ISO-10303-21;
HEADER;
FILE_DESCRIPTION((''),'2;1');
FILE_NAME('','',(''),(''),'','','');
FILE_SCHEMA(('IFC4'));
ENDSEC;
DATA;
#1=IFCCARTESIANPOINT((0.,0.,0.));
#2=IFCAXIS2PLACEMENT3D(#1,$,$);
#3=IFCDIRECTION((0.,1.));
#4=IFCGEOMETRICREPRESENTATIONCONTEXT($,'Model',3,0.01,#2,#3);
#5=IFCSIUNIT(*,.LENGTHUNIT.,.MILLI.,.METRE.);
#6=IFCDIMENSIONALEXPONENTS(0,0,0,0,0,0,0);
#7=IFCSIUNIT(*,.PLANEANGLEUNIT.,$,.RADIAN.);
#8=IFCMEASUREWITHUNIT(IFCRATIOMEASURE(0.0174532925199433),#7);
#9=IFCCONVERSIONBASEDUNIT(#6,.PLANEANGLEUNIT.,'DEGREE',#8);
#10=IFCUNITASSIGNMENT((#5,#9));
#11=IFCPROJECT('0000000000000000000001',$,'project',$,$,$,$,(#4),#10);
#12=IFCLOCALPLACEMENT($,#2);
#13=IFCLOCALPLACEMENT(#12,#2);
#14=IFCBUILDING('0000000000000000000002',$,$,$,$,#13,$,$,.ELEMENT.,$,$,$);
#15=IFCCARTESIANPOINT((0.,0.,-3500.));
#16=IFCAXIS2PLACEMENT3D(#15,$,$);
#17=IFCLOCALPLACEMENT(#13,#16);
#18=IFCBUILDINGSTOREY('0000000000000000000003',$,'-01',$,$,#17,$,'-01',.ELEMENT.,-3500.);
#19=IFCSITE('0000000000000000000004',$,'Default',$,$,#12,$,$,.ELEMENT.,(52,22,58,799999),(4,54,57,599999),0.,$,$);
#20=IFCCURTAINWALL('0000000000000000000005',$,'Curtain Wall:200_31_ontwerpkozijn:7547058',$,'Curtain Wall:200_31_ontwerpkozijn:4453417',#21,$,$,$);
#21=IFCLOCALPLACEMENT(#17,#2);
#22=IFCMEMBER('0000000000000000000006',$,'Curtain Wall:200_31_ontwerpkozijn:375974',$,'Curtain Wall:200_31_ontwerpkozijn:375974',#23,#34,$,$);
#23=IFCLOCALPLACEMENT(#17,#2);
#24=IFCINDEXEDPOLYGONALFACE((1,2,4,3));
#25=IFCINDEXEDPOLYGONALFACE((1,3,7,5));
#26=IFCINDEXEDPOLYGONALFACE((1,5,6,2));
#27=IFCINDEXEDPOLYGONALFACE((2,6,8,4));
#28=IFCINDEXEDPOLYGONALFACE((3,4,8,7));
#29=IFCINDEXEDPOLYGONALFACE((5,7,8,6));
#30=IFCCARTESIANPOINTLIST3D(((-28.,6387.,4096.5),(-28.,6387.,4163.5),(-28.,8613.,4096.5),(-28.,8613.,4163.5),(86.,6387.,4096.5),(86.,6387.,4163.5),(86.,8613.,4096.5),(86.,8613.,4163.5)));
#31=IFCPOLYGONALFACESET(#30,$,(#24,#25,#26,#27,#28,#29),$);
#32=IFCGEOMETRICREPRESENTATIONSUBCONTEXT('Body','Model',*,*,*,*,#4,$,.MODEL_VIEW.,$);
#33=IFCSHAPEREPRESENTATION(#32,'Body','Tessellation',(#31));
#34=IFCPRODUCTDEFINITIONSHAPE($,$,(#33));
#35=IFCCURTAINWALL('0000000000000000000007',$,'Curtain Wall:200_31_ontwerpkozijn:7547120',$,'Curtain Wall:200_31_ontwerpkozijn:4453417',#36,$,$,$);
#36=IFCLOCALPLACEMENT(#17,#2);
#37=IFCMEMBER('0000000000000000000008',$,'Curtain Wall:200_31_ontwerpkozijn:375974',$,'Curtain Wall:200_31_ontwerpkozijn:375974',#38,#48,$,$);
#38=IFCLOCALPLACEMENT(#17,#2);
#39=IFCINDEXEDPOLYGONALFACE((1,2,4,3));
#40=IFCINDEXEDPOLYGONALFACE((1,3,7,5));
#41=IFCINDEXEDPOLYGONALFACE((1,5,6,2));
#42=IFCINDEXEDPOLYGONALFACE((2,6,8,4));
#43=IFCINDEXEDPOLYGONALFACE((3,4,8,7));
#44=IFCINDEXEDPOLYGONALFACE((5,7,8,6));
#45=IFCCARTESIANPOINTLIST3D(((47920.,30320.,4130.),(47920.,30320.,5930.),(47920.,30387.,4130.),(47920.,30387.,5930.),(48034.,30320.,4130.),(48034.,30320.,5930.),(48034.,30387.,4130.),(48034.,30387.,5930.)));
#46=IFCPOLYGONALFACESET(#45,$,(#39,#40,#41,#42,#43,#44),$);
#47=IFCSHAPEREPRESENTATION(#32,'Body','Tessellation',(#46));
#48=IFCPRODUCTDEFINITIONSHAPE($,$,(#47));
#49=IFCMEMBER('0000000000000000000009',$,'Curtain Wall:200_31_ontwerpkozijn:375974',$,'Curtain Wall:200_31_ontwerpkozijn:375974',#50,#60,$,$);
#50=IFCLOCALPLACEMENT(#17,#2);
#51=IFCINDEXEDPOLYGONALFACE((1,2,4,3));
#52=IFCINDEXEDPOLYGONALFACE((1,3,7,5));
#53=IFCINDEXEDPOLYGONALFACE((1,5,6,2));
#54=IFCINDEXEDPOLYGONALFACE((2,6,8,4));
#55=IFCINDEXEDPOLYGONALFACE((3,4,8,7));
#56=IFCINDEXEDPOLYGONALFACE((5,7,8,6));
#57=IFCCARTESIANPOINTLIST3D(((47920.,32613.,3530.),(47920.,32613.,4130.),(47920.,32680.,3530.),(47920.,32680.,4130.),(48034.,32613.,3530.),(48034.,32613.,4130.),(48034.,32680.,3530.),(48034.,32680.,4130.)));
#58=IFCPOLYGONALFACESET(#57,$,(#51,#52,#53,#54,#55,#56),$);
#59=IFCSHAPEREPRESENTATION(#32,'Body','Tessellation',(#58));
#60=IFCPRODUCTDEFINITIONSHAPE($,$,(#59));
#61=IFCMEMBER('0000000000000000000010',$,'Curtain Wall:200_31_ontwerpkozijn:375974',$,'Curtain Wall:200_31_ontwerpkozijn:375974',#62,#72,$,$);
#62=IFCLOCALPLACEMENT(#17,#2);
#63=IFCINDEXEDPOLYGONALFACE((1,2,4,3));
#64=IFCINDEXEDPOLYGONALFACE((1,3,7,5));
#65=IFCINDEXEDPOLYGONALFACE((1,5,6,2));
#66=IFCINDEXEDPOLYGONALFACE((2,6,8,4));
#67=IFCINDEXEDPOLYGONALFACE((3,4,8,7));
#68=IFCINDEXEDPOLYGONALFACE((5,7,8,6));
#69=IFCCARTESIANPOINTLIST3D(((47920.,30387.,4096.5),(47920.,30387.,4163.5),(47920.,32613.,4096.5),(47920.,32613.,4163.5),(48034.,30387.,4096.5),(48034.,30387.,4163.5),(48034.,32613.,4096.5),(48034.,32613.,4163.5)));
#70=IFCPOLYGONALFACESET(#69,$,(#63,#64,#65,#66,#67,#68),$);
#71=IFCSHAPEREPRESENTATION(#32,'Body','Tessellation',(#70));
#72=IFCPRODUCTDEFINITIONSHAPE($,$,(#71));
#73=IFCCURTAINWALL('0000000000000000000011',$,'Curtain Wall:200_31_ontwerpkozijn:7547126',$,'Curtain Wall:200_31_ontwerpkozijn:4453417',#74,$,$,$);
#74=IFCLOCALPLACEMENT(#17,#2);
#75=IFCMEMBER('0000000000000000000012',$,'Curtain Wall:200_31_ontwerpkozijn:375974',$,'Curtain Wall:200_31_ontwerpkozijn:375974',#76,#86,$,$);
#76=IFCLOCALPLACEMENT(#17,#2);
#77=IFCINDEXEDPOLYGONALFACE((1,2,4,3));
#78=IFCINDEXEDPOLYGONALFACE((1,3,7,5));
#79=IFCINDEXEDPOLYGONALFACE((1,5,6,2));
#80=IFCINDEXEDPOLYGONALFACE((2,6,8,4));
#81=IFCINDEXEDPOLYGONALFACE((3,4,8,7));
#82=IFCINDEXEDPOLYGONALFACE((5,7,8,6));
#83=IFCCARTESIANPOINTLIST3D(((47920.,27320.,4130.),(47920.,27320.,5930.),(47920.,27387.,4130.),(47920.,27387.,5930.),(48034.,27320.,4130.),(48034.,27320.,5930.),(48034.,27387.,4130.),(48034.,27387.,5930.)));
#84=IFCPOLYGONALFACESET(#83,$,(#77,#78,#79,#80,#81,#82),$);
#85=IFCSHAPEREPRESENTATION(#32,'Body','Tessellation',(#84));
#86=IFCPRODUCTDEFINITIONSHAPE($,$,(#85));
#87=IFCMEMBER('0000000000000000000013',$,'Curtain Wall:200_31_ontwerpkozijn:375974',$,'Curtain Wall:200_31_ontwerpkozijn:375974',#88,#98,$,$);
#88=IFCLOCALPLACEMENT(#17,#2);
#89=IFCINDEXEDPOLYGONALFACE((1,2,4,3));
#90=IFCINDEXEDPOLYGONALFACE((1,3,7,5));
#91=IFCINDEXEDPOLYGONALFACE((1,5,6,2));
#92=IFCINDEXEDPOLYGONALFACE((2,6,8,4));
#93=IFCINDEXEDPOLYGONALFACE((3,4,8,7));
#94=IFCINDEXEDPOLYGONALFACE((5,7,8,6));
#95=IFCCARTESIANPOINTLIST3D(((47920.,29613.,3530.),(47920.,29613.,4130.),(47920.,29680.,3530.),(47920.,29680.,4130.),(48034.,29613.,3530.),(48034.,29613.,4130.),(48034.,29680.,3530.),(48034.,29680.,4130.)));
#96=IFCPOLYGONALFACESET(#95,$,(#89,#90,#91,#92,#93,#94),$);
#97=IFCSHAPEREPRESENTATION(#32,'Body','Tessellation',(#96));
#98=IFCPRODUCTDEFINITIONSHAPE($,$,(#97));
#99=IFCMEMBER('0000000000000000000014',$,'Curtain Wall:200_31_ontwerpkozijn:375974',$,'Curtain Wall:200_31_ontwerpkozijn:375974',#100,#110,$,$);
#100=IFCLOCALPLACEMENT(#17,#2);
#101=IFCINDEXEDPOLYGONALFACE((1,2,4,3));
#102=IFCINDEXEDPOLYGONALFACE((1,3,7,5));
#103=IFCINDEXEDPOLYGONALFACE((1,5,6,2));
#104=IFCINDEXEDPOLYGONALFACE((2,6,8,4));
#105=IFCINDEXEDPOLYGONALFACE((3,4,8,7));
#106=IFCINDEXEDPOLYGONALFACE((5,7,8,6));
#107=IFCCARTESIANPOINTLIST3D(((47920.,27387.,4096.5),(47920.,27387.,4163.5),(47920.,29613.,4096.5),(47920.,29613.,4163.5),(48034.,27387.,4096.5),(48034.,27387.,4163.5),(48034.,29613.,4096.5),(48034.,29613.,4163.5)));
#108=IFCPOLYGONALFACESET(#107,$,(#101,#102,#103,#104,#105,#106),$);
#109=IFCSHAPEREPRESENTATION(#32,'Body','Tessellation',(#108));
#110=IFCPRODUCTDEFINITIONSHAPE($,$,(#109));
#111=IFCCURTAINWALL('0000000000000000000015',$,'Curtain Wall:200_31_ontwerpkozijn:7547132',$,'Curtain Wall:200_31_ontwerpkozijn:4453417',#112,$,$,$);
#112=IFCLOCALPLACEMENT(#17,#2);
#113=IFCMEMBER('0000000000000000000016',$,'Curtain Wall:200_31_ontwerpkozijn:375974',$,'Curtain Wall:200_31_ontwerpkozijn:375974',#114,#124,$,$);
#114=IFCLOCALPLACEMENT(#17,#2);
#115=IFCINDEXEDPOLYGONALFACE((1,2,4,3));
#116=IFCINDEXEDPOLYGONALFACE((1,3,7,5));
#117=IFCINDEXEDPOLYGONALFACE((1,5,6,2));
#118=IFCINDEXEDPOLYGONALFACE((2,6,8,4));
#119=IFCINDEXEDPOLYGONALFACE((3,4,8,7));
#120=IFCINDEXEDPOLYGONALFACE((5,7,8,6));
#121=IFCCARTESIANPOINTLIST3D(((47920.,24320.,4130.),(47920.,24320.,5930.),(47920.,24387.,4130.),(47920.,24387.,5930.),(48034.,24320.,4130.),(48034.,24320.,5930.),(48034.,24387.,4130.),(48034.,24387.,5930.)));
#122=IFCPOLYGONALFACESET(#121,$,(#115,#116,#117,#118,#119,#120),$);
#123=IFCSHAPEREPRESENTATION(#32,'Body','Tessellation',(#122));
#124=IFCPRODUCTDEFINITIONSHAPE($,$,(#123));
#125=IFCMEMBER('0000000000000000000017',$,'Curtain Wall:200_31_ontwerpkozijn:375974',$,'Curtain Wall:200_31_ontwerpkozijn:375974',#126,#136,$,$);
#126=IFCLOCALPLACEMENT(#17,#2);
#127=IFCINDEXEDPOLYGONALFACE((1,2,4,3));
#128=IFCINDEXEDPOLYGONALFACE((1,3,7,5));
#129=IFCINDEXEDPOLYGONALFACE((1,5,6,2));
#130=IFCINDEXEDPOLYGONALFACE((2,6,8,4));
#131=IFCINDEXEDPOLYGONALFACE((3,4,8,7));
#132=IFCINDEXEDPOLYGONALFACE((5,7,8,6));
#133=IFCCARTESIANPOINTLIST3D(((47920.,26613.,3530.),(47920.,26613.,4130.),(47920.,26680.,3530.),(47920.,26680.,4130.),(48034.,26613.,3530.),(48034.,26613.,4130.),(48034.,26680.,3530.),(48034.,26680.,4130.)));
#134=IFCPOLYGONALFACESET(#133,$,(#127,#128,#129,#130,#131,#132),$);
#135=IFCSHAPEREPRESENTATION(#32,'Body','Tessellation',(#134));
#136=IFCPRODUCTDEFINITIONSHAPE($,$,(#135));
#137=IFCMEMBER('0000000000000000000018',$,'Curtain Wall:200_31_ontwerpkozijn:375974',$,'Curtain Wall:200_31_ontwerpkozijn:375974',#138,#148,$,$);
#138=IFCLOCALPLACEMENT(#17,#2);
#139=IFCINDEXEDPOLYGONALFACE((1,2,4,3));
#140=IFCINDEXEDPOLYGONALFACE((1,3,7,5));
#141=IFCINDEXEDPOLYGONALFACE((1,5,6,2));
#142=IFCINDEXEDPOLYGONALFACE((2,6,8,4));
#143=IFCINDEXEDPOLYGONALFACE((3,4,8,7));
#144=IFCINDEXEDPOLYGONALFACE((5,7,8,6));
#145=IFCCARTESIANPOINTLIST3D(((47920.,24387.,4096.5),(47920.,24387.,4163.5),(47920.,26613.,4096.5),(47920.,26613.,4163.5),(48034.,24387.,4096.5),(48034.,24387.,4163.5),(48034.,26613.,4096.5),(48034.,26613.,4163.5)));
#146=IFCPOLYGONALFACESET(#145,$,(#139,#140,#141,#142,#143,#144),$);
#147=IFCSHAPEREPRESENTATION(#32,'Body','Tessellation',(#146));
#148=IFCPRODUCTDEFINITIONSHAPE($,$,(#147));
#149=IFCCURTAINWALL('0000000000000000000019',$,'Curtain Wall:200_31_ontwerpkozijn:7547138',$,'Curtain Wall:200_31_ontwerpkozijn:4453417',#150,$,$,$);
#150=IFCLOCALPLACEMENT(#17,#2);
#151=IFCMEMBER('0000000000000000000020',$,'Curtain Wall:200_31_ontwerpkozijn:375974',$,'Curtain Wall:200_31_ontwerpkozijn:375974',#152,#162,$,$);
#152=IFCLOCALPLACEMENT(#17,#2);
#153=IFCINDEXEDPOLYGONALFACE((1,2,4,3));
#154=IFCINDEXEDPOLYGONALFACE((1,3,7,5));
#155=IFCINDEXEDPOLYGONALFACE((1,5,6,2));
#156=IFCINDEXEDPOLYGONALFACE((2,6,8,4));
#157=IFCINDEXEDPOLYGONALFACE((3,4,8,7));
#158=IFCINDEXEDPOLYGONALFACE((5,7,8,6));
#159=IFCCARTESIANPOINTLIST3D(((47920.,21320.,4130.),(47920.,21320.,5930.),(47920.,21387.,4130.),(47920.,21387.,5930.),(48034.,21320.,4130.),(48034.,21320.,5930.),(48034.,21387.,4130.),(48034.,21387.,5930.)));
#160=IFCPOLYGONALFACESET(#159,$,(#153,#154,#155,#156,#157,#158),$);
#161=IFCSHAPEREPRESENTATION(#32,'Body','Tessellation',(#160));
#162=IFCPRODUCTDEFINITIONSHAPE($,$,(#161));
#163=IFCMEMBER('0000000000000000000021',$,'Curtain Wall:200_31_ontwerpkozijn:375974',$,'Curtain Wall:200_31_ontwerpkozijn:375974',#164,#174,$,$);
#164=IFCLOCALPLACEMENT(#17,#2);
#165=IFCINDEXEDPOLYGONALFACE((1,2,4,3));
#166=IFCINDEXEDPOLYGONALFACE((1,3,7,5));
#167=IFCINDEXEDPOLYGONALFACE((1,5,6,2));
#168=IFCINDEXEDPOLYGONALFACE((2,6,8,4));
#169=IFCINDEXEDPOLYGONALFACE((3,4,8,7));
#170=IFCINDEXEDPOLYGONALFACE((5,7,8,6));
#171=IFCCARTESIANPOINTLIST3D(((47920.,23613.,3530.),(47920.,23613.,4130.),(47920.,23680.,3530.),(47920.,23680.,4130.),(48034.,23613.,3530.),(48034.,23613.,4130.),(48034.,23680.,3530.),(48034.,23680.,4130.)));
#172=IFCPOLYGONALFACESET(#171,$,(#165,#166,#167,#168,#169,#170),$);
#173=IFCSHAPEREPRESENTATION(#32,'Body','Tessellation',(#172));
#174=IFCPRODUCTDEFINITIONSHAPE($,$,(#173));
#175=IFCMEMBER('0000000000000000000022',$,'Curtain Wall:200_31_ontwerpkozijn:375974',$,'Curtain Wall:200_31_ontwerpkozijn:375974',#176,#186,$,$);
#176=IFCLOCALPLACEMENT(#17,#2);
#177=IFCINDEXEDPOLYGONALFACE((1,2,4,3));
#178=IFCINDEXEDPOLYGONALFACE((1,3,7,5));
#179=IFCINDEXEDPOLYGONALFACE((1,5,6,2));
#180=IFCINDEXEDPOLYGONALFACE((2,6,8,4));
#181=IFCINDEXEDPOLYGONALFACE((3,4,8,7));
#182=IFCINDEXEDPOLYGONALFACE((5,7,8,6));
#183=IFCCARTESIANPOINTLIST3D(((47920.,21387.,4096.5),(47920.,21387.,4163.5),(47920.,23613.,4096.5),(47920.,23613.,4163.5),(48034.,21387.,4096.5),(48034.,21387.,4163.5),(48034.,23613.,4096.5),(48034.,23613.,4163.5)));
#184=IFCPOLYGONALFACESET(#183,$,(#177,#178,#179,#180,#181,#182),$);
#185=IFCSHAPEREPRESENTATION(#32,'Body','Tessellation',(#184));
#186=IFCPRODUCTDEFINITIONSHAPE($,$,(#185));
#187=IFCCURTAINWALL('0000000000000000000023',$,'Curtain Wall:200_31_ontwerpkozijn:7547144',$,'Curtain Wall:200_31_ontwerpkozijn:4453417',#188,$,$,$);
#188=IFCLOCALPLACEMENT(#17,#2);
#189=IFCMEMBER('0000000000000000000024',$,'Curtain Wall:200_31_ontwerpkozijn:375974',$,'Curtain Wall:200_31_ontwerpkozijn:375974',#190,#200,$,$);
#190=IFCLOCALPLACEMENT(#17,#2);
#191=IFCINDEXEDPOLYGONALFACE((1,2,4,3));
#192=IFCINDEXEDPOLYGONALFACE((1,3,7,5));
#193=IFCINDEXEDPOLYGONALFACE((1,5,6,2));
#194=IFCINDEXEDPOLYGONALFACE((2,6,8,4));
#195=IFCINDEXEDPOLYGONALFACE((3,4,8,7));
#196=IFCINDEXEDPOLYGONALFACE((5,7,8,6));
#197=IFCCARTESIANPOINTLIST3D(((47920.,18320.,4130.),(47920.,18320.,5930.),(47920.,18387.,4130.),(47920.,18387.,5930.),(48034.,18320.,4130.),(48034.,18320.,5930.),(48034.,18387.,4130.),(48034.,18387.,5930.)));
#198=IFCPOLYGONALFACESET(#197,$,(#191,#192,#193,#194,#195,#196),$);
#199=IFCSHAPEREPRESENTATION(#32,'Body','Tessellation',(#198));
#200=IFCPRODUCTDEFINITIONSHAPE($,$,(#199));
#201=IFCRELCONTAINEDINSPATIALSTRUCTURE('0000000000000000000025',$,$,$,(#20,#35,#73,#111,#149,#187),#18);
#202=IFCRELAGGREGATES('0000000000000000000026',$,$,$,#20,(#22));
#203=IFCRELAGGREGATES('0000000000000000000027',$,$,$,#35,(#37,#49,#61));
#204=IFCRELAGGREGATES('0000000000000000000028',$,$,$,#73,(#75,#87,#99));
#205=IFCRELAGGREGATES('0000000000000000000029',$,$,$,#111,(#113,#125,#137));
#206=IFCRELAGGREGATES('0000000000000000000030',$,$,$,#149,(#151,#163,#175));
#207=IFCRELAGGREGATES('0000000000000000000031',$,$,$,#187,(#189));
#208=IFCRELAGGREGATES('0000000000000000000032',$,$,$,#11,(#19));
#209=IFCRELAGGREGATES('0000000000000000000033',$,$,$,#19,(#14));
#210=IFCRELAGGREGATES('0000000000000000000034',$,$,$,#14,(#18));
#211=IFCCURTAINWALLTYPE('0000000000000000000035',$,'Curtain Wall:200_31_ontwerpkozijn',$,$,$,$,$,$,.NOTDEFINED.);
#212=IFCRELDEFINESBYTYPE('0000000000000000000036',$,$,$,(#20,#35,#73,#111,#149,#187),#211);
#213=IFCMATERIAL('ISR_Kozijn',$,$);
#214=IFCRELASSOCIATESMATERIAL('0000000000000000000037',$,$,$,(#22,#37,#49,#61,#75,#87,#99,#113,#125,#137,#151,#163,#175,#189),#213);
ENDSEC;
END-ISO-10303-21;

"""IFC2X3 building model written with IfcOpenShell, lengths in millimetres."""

from ifc_helpers import new_model, entity, si_unit, converted_unit, direction, frame, frame_2d, origin, place, context, subcontext, project, spatial, rectangle, extrude, material, type_object, element, aggregate, save


model = new_model("IFC2X3")

# Units and contexts
model_context = context("Model", 3, precision=0.01, world=origin(), true_north=direction((0.0, 1.0)))
body_context = subcontext(model_context, "Body", "Model", "MODEL_VIEW")
ifc_project = project(units=[si_unit("LENGTHUNIT", "METRE", prefix="MILLI"), converted_unit("PLANEANGLEUNIT", "DEGREE", entity("IfcRatioMeasure", 0.0174532925199433), si_unit("PLANEANGLEUNIT", "RADIAN"), dimensions=[0, 0, 0, 0, 0, 0, 0])], contexts=[model_context])

# Site, building, storey
site_placement = place(None, origin())
site = spatial("IfcSite", under=ifc_project, at=site_placement, Name="Default", CompositionType="ELEMENT", RefLatitude=(52, 22, 58, 799999), RefLongitude=(4, 54, 57, 599999), RefElevation=0.0)
building_placement = place(site_placement, origin())
building = spatial("IfcBuilding", under=site, at=building_placement, CompositionType="ELEMENT")
storey_placement = place(building_placement, frame((0.0, 0.0, -3500.0)))
storey = spatial("IfcBuildingStorey", under=building, at=storey_placement, Name="-01", LongName="-01", CompositionType="ELEMENT", Elevation=-3500.0)

# Curtain wall, member
curtain_wall_type = type_object("IfcCurtainWallType", Name="Curtain Wall:200_31_ontwerpkozijn", PredefinedType="NOTDEFINED")
curtain_wall_1_placement = place(storey_placement, frame((0.0, 0.0, 3500.0)))
curtain_wall_1 = element("IfcCurtainWall", 1, at=curtain_wall_1_placement, inside=storey, type_object=curtain_wall_type, Name="Curtain Wall:200_31_ontwerpkozijn:7547058", ObjectType="Curtain Wall:200_31_ontwerpkozijn:4453417")
ifc_material = material(Name="ISR_Kozijn")
member_1_placement = place(curtain_wall_1_placement, frame((0.0, 0.0, -3500.0)))
member_1 = element("IfcMember", 2, at=member_1_placement, material=ifc_material, Name="Curtain Wall:200_31_ontwerpkozijn:375974", ObjectType="Curtain Wall:200_31_ontwerpkozijn:375974", context=body_context, shape_type="SweptSolid", body=[
    extrude(rectangle(XDim=67.0, YDim=114.0, at=frame_2d((0.0, 0.0), x_axis=(1.0, 0.0))), frame((29.0, 6387.0, 4130.0), z_axis=(0.0, 1.0, 0.0), x_axis=(0.0, 0.0, -1.0)), (0.0, 0.0, 1.0), 2226.0),
])
aggregate(curtain_wall_1, [member_1])

# Curtain walls, members
curtain_wall_2_placement = place(storey_placement, frame((0.0, 0.0, 3500.0)))
curtain_wall_2 = element("IfcCurtainWall", 3, at=curtain_wall_2_placement, inside=storey, type_object=curtain_wall_type, Name="Curtain Wall:200_31_ontwerpkozijn:7547120", ObjectType="Curtain Wall:200_31_ontwerpkozijn:4453417")
member_2_placement = place(curtain_wall_2_placement, frame((0.0, 0.0, -3500.0)))
member_2 = element("IfcMember", 4, at=member_2_placement, material=ifc_material, Name="Curtain Wall:200_31_ontwerpkozijn:375974", ObjectType="Curtain Wall:200_31_ontwerpkozijn:375974", context=body_context, shape_type="SweptSolid", body=[
    extrude(rectangle(XDim=114.0, YDim=67.0, at=frame_2d((0.0, 0.0), x_axis=(1.0, 0.0))), frame((47977.0, 30353.5, 4130.0), z_axis=(0.0, 0.0, 1.0), x_axis=(-1.0, 0.0, 0.0)), (0.0, 0.0, 1.0), 1800.0),
])
member_3_placement = place(curtain_wall_2_placement, frame((0.0, 0.0, -3500.0)))
member_3 = element("IfcMember", 5, at=member_3_placement, material=ifc_material, Name="Curtain Wall:200_31_ontwerpkozijn:375974", ObjectType="Curtain Wall:200_31_ontwerpkozijn:375974", context=body_context, shape_type="SweptSolid", body=[
    extrude(rectangle(XDim=114.0, YDim=67.0, at=frame_2d((0.0, 0.0), x_axis=(1.0, 0.0))), frame((47977.0, 32646.5, 4130.0), z_axis=(0.0, 0.0, -1.0), x_axis=(-1.0, 0.0, 0.0)), (0.0, 0.0, 1.0), 600.0),
])
member_4_placement = place(curtain_wall_2_placement, frame((0.0, 0.0, -3500.0)))
member_4 = element("IfcMember", 6, at=member_4_placement, material=ifc_material, Name="Curtain Wall:200_31_ontwerpkozijn:375974", ObjectType="Curtain Wall:200_31_ontwerpkozijn:375974", context=body_context, shape_type="SweptSolid", body=[
    extrude(rectangle(XDim=67.0, YDim=114.0, at=frame_2d((0.0, 0.0), x_axis=(1.0, 0.0))), frame((47977.0, 30387.0, 4130.0), z_axis=(0.0, 1.0, 0.0), x_axis=(0.0, 0.0, -1.0)), (0.0, 0.0, 1.0), 2226.0),
])
aggregate(curtain_wall_2, [member_2, member_3, member_4])
curtain_wall_3_placement = place(storey_placement, frame((0.0, 0.0, 3500.0)))
curtain_wall_3 = element("IfcCurtainWall", 7, at=curtain_wall_3_placement, inside=storey, type_object=curtain_wall_type, Name="Curtain Wall:200_31_ontwerpkozijn:7547126", ObjectType="Curtain Wall:200_31_ontwerpkozijn:4453417")
member_5_placement = place(curtain_wall_3_placement, frame((0.0, 0.0, -3500.0)))
member_5 = element("IfcMember", 8, at=member_5_placement, material=ifc_material, Name="Curtain Wall:200_31_ontwerpkozijn:375974", ObjectType="Curtain Wall:200_31_ontwerpkozijn:375974", context=body_context, shape_type="SweptSolid", body=[
    extrude(rectangle(XDim=114.0, YDim=67.0, at=frame_2d((0.0, 0.0), x_axis=(1.0, 0.0))), frame((47977.0, 27353.5, 4130.0), z_axis=(0.0, 0.0, 1.0), x_axis=(-1.0, 0.0, 0.0)), (0.0, 0.0, 1.0), 1800.0),
])
member_6_placement = place(curtain_wall_3_placement, frame((0.0, 0.0, -3500.0)))
member_6 = element("IfcMember", 9, at=member_6_placement, material=ifc_material, Name="Curtain Wall:200_31_ontwerpkozijn:375974", ObjectType="Curtain Wall:200_31_ontwerpkozijn:375974", context=body_context, shape_type="SweptSolid", body=[
    extrude(rectangle(XDim=114.0, YDim=67.0, at=frame_2d((0.0, 0.0), x_axis=(1.0, 0.0))), frame((47977.0, 29646.5, 4130.0), z_axis=(0.0, 0.0, -1.0), x_axis=(-1.0, 0.0, 0.0)), (0.0, 0.0, 1.0), 600.0),
])
member_7_placement = place(curtain_wall_3_placement, frame((0.0, 0.0, -3500.0)))
member_7 = element("IfcMember", 10, at=member_7_placement, material=ifc_material, Name="Curtain Wall:200_31_ontwerpkozijn:375974", ObjectType="Curtain Wall:200_31_ontwerpkozijn:375974", context=body_context, shape_type="SweptSolid", body=[
    extrude(rectangle(XDim=67.0, YDim=114.0, at=frame_2d((0.0, 0.0), x_axis=(1.0, 0.0))), frame((47977.0, 27387.0, 4130.0), z_axis=(0.0, 1.0, 0.0), x_axis=(0.0, 0.0, -1.0)), (0.0, 0.0, 1.0), 2226.0),
])
aggregate(curtain_wall_3, [member_5, member_6, member_7])
curtain_wall_4_placement = place(storey_placement, frame((0.0, 0.0, 3500.0)))
curtain_wall_4 = element("IfcCurtainWall", 11, at=curtain_wall_4_placement, inside=storey, type_object=curtain_wall_type, Name="Curtain Wall:200_31_ontwerpkozijn:7547132", ObjectType="Curtain Wall:200_31_ontwerpkozijn:4453417")
member_8_placement = place(curtain_wall_4_placement, frame((0.0, 0.0, -3500.0)))
member_8 = element("IfcMember", 12, at=member_8_placement, material=ifc_material, Name="Curtain Wall:200_31_ontwerpkozijn:375974", ObjectType="Curtain Wall:200_31_ontwerpkozijn:375974", context=body_context, shape_type="SweptSolid", body=[
    extrude(rectangle(XDim=114.0, YDim=67.0, at=frame_2d((0.0, 0.0), x_axis=(1.0, 0.0))), frame((47977.0, 24353.5, 4130.0), z_axis=(0.0, 0.0, 1.0), x_axis=(-1.0, 0.0, 0.0)), (0.0, 0.0, 1.0), 1800.0),
])
member_9_placement = place(curtain_wall_4_placement, frame((0.0, 0.0, -3500.0)))
member_9 = element("IfcMember", 13, at=member_9_placement, material=ifc_material, Name="Curtain Wall:200_31_ontwerpkozijn:375974", ObjectType="Curtain Wall:200_31_ontwerpkozijn:375974", context=body_context, shape_type="SweptSolid", body=[
    extrude(rectangle(XDim=114.0, YDim=67.0, at=frame_2d((0.0, 0.0), x_axis=(1.0, 0.0))), frame((47977.0, 26646.5, 4130.0), z_axis=(0.0, 0.0, -1.0), x_axis=(-1.0, 0.0, 0.0)), (0.0, 0.0, 1.0), 600.0),
])
member_10_placement = place(curtain_wall_4_placement, frame((0.0, 0.0, -3500.0)))
member_10 = element("IfcMember", 14, at=member_10_placement, material=ifc_material, Name="Curtain Wall:200_31_ontwerpkozijn:375974", ObjectType="Curtain Wall:200_31_ontwerpkozijn:375974", context=body_context, shape_type="SweptSolid", body=[
    extrude(rectangle(XDim=67.0, YDim=114.0, at=frame_2d((0.0, 0.0), x_axis=(1.0, 0.0))), frame((47977.0, 24387.0, 4130.0), z_axis=(0.0, 1.0, 0.0), x_axis=(0.0, 0.0, -1.0)), (0.0, 0.0, 1.0), 2226.0),
])
aggregate(curtain_wall_4, [member_8, member_9, member_10])
curtain_wall_5_placement = place(storey_placement, frame((0.0, 0.0, 3500.0)))
curtain_wall_5 = element("IfcCurtainWall", 15, at=curtain_wall_5_placement, inside=storey, type_object=curtain_wall_type, Name="Curtain Wall:200_31_ontwerpkozijn:7547138", ObjectType="Curtain Wall:200_31_ontwerpkozijn:4453417")
member_11_placement = place(curtain_wall_5_placement, frame((0.0, 0.0, -3500.0)))
member_11 = element("IfcMember", 16, at=member_11_placement, material=ifc_material, Name="Curtain Wall:200_31_ontwerpkozijn:375974", ObjectType="Curtain Wall:200_31_ontwerpkozijn:375974", context=body_context, shape_type="SweptSolid", body=[
    extrude(rectangle(XDim=114.0, YDim=67.0, at=frame_2d((0.0, 0.0), x_axis=(1.0, 0.0))), frame((47977.0, 21353.5, 4130.0), z_axis=(0.0, 0.0, 1.0), x_axis=(-1.0, 0.0, 0.0)), (0.0, 0.0, 1.0), 1800.0),
])
member_12_placement = place(curtain_wall_5_placement, frame((0.0, 0.0, -3500.0)))
member_12 = element("IfcMember", 17, at=member_12_placement, material=ifc_material, Name="Curtain Wall:200_31_ontwerpkozijn:375974", ObjectType="Curtain Wall:200_31_ontwerpkozijn:375974", context=body_context, shape_type="SweptSolid", body=[
    extrude(rectangle(XDim=114.0, YDim=67.0, at=frame_2d((0.0, 0.0), x_axis=(1.0, 0.0))), frame((47977.0, 23646.5, 4130.0), z_axis=(0.0, 0.0, -1.0), x_axis=(-1.0, 0.0, 0.0)), (0.0, 0.0, 1.0), 600.0),
])
member_13_placement = place(curtain_wall_5_placement, frame((0.0, 0.0, -3500.0)))
member_13 = element("IfcMember", 18, at=member_13_placement, material=ifc_material, Name="Curtain Wall:200_31_ontwerpkozijn:375974", ObjectType="Curtain Wall:200_31_ontwerpkozijn:375974", context=body_context, shape_type="SweptSolid", body=[
    extrude(rectangle(XDim=67.0, YDim=114.0, at=frame_2d((0.0, 0.0), x_axis=(1.0, 0.0))), frame((47977.0, 21387.0, 4130.0), z_axis=(0.0, 1.0, 0.0), x_axis=(0.0, 0.0, -1.0)), (0.0, 0.0, 1.0), 2226.0),
])
aggregate(curtain_wall_5, [member_11, member_12, member_13])
curtain_wall_6_placement = place(storey_placement, frame((0.0, 0.0, 3500.0)))
curtain_wall_6 = element("IfcCurtainWall", 19, at=curtain_wall_6_placement, inside=storey, type_object=curtain_wall_type, Name="Curtain Wall:200_31_ontwerpkozijn:7547144", ObjectType="Curtain Wall:200_31_ontwerpkozijn:4453417")
member_14_placement = place(curtain_wall_6_placement, frame((0.0, 0.0, -3500.0)))
member_14 = element("IfcMember", 20, at=member_14_placement, material=ifc_material, Name="Curtain Wall:200_31_ontwerpkozijn:375974", ObjectType="Curtain Wall:200_31_ontwerpkozijn:375974", context=body_context, shape_type="SweptSolid", body=[
    extrude(rectangle(XDim=114.0, YDim=67.0, at=frame_2d((0.0, 0.0), x_axis=(1.0, 0.0))), frame((47977.0, 18353.5, 4130.0), z_axis=(0.0, 0.0, 1.0), x_axis=(-1.0, 0.0, 0.0)), (0.0, 0.0, 1.0), 1800.0),
])
aggregate(curtain_wall_6, [member_14])

save(model, "model.ifc")
